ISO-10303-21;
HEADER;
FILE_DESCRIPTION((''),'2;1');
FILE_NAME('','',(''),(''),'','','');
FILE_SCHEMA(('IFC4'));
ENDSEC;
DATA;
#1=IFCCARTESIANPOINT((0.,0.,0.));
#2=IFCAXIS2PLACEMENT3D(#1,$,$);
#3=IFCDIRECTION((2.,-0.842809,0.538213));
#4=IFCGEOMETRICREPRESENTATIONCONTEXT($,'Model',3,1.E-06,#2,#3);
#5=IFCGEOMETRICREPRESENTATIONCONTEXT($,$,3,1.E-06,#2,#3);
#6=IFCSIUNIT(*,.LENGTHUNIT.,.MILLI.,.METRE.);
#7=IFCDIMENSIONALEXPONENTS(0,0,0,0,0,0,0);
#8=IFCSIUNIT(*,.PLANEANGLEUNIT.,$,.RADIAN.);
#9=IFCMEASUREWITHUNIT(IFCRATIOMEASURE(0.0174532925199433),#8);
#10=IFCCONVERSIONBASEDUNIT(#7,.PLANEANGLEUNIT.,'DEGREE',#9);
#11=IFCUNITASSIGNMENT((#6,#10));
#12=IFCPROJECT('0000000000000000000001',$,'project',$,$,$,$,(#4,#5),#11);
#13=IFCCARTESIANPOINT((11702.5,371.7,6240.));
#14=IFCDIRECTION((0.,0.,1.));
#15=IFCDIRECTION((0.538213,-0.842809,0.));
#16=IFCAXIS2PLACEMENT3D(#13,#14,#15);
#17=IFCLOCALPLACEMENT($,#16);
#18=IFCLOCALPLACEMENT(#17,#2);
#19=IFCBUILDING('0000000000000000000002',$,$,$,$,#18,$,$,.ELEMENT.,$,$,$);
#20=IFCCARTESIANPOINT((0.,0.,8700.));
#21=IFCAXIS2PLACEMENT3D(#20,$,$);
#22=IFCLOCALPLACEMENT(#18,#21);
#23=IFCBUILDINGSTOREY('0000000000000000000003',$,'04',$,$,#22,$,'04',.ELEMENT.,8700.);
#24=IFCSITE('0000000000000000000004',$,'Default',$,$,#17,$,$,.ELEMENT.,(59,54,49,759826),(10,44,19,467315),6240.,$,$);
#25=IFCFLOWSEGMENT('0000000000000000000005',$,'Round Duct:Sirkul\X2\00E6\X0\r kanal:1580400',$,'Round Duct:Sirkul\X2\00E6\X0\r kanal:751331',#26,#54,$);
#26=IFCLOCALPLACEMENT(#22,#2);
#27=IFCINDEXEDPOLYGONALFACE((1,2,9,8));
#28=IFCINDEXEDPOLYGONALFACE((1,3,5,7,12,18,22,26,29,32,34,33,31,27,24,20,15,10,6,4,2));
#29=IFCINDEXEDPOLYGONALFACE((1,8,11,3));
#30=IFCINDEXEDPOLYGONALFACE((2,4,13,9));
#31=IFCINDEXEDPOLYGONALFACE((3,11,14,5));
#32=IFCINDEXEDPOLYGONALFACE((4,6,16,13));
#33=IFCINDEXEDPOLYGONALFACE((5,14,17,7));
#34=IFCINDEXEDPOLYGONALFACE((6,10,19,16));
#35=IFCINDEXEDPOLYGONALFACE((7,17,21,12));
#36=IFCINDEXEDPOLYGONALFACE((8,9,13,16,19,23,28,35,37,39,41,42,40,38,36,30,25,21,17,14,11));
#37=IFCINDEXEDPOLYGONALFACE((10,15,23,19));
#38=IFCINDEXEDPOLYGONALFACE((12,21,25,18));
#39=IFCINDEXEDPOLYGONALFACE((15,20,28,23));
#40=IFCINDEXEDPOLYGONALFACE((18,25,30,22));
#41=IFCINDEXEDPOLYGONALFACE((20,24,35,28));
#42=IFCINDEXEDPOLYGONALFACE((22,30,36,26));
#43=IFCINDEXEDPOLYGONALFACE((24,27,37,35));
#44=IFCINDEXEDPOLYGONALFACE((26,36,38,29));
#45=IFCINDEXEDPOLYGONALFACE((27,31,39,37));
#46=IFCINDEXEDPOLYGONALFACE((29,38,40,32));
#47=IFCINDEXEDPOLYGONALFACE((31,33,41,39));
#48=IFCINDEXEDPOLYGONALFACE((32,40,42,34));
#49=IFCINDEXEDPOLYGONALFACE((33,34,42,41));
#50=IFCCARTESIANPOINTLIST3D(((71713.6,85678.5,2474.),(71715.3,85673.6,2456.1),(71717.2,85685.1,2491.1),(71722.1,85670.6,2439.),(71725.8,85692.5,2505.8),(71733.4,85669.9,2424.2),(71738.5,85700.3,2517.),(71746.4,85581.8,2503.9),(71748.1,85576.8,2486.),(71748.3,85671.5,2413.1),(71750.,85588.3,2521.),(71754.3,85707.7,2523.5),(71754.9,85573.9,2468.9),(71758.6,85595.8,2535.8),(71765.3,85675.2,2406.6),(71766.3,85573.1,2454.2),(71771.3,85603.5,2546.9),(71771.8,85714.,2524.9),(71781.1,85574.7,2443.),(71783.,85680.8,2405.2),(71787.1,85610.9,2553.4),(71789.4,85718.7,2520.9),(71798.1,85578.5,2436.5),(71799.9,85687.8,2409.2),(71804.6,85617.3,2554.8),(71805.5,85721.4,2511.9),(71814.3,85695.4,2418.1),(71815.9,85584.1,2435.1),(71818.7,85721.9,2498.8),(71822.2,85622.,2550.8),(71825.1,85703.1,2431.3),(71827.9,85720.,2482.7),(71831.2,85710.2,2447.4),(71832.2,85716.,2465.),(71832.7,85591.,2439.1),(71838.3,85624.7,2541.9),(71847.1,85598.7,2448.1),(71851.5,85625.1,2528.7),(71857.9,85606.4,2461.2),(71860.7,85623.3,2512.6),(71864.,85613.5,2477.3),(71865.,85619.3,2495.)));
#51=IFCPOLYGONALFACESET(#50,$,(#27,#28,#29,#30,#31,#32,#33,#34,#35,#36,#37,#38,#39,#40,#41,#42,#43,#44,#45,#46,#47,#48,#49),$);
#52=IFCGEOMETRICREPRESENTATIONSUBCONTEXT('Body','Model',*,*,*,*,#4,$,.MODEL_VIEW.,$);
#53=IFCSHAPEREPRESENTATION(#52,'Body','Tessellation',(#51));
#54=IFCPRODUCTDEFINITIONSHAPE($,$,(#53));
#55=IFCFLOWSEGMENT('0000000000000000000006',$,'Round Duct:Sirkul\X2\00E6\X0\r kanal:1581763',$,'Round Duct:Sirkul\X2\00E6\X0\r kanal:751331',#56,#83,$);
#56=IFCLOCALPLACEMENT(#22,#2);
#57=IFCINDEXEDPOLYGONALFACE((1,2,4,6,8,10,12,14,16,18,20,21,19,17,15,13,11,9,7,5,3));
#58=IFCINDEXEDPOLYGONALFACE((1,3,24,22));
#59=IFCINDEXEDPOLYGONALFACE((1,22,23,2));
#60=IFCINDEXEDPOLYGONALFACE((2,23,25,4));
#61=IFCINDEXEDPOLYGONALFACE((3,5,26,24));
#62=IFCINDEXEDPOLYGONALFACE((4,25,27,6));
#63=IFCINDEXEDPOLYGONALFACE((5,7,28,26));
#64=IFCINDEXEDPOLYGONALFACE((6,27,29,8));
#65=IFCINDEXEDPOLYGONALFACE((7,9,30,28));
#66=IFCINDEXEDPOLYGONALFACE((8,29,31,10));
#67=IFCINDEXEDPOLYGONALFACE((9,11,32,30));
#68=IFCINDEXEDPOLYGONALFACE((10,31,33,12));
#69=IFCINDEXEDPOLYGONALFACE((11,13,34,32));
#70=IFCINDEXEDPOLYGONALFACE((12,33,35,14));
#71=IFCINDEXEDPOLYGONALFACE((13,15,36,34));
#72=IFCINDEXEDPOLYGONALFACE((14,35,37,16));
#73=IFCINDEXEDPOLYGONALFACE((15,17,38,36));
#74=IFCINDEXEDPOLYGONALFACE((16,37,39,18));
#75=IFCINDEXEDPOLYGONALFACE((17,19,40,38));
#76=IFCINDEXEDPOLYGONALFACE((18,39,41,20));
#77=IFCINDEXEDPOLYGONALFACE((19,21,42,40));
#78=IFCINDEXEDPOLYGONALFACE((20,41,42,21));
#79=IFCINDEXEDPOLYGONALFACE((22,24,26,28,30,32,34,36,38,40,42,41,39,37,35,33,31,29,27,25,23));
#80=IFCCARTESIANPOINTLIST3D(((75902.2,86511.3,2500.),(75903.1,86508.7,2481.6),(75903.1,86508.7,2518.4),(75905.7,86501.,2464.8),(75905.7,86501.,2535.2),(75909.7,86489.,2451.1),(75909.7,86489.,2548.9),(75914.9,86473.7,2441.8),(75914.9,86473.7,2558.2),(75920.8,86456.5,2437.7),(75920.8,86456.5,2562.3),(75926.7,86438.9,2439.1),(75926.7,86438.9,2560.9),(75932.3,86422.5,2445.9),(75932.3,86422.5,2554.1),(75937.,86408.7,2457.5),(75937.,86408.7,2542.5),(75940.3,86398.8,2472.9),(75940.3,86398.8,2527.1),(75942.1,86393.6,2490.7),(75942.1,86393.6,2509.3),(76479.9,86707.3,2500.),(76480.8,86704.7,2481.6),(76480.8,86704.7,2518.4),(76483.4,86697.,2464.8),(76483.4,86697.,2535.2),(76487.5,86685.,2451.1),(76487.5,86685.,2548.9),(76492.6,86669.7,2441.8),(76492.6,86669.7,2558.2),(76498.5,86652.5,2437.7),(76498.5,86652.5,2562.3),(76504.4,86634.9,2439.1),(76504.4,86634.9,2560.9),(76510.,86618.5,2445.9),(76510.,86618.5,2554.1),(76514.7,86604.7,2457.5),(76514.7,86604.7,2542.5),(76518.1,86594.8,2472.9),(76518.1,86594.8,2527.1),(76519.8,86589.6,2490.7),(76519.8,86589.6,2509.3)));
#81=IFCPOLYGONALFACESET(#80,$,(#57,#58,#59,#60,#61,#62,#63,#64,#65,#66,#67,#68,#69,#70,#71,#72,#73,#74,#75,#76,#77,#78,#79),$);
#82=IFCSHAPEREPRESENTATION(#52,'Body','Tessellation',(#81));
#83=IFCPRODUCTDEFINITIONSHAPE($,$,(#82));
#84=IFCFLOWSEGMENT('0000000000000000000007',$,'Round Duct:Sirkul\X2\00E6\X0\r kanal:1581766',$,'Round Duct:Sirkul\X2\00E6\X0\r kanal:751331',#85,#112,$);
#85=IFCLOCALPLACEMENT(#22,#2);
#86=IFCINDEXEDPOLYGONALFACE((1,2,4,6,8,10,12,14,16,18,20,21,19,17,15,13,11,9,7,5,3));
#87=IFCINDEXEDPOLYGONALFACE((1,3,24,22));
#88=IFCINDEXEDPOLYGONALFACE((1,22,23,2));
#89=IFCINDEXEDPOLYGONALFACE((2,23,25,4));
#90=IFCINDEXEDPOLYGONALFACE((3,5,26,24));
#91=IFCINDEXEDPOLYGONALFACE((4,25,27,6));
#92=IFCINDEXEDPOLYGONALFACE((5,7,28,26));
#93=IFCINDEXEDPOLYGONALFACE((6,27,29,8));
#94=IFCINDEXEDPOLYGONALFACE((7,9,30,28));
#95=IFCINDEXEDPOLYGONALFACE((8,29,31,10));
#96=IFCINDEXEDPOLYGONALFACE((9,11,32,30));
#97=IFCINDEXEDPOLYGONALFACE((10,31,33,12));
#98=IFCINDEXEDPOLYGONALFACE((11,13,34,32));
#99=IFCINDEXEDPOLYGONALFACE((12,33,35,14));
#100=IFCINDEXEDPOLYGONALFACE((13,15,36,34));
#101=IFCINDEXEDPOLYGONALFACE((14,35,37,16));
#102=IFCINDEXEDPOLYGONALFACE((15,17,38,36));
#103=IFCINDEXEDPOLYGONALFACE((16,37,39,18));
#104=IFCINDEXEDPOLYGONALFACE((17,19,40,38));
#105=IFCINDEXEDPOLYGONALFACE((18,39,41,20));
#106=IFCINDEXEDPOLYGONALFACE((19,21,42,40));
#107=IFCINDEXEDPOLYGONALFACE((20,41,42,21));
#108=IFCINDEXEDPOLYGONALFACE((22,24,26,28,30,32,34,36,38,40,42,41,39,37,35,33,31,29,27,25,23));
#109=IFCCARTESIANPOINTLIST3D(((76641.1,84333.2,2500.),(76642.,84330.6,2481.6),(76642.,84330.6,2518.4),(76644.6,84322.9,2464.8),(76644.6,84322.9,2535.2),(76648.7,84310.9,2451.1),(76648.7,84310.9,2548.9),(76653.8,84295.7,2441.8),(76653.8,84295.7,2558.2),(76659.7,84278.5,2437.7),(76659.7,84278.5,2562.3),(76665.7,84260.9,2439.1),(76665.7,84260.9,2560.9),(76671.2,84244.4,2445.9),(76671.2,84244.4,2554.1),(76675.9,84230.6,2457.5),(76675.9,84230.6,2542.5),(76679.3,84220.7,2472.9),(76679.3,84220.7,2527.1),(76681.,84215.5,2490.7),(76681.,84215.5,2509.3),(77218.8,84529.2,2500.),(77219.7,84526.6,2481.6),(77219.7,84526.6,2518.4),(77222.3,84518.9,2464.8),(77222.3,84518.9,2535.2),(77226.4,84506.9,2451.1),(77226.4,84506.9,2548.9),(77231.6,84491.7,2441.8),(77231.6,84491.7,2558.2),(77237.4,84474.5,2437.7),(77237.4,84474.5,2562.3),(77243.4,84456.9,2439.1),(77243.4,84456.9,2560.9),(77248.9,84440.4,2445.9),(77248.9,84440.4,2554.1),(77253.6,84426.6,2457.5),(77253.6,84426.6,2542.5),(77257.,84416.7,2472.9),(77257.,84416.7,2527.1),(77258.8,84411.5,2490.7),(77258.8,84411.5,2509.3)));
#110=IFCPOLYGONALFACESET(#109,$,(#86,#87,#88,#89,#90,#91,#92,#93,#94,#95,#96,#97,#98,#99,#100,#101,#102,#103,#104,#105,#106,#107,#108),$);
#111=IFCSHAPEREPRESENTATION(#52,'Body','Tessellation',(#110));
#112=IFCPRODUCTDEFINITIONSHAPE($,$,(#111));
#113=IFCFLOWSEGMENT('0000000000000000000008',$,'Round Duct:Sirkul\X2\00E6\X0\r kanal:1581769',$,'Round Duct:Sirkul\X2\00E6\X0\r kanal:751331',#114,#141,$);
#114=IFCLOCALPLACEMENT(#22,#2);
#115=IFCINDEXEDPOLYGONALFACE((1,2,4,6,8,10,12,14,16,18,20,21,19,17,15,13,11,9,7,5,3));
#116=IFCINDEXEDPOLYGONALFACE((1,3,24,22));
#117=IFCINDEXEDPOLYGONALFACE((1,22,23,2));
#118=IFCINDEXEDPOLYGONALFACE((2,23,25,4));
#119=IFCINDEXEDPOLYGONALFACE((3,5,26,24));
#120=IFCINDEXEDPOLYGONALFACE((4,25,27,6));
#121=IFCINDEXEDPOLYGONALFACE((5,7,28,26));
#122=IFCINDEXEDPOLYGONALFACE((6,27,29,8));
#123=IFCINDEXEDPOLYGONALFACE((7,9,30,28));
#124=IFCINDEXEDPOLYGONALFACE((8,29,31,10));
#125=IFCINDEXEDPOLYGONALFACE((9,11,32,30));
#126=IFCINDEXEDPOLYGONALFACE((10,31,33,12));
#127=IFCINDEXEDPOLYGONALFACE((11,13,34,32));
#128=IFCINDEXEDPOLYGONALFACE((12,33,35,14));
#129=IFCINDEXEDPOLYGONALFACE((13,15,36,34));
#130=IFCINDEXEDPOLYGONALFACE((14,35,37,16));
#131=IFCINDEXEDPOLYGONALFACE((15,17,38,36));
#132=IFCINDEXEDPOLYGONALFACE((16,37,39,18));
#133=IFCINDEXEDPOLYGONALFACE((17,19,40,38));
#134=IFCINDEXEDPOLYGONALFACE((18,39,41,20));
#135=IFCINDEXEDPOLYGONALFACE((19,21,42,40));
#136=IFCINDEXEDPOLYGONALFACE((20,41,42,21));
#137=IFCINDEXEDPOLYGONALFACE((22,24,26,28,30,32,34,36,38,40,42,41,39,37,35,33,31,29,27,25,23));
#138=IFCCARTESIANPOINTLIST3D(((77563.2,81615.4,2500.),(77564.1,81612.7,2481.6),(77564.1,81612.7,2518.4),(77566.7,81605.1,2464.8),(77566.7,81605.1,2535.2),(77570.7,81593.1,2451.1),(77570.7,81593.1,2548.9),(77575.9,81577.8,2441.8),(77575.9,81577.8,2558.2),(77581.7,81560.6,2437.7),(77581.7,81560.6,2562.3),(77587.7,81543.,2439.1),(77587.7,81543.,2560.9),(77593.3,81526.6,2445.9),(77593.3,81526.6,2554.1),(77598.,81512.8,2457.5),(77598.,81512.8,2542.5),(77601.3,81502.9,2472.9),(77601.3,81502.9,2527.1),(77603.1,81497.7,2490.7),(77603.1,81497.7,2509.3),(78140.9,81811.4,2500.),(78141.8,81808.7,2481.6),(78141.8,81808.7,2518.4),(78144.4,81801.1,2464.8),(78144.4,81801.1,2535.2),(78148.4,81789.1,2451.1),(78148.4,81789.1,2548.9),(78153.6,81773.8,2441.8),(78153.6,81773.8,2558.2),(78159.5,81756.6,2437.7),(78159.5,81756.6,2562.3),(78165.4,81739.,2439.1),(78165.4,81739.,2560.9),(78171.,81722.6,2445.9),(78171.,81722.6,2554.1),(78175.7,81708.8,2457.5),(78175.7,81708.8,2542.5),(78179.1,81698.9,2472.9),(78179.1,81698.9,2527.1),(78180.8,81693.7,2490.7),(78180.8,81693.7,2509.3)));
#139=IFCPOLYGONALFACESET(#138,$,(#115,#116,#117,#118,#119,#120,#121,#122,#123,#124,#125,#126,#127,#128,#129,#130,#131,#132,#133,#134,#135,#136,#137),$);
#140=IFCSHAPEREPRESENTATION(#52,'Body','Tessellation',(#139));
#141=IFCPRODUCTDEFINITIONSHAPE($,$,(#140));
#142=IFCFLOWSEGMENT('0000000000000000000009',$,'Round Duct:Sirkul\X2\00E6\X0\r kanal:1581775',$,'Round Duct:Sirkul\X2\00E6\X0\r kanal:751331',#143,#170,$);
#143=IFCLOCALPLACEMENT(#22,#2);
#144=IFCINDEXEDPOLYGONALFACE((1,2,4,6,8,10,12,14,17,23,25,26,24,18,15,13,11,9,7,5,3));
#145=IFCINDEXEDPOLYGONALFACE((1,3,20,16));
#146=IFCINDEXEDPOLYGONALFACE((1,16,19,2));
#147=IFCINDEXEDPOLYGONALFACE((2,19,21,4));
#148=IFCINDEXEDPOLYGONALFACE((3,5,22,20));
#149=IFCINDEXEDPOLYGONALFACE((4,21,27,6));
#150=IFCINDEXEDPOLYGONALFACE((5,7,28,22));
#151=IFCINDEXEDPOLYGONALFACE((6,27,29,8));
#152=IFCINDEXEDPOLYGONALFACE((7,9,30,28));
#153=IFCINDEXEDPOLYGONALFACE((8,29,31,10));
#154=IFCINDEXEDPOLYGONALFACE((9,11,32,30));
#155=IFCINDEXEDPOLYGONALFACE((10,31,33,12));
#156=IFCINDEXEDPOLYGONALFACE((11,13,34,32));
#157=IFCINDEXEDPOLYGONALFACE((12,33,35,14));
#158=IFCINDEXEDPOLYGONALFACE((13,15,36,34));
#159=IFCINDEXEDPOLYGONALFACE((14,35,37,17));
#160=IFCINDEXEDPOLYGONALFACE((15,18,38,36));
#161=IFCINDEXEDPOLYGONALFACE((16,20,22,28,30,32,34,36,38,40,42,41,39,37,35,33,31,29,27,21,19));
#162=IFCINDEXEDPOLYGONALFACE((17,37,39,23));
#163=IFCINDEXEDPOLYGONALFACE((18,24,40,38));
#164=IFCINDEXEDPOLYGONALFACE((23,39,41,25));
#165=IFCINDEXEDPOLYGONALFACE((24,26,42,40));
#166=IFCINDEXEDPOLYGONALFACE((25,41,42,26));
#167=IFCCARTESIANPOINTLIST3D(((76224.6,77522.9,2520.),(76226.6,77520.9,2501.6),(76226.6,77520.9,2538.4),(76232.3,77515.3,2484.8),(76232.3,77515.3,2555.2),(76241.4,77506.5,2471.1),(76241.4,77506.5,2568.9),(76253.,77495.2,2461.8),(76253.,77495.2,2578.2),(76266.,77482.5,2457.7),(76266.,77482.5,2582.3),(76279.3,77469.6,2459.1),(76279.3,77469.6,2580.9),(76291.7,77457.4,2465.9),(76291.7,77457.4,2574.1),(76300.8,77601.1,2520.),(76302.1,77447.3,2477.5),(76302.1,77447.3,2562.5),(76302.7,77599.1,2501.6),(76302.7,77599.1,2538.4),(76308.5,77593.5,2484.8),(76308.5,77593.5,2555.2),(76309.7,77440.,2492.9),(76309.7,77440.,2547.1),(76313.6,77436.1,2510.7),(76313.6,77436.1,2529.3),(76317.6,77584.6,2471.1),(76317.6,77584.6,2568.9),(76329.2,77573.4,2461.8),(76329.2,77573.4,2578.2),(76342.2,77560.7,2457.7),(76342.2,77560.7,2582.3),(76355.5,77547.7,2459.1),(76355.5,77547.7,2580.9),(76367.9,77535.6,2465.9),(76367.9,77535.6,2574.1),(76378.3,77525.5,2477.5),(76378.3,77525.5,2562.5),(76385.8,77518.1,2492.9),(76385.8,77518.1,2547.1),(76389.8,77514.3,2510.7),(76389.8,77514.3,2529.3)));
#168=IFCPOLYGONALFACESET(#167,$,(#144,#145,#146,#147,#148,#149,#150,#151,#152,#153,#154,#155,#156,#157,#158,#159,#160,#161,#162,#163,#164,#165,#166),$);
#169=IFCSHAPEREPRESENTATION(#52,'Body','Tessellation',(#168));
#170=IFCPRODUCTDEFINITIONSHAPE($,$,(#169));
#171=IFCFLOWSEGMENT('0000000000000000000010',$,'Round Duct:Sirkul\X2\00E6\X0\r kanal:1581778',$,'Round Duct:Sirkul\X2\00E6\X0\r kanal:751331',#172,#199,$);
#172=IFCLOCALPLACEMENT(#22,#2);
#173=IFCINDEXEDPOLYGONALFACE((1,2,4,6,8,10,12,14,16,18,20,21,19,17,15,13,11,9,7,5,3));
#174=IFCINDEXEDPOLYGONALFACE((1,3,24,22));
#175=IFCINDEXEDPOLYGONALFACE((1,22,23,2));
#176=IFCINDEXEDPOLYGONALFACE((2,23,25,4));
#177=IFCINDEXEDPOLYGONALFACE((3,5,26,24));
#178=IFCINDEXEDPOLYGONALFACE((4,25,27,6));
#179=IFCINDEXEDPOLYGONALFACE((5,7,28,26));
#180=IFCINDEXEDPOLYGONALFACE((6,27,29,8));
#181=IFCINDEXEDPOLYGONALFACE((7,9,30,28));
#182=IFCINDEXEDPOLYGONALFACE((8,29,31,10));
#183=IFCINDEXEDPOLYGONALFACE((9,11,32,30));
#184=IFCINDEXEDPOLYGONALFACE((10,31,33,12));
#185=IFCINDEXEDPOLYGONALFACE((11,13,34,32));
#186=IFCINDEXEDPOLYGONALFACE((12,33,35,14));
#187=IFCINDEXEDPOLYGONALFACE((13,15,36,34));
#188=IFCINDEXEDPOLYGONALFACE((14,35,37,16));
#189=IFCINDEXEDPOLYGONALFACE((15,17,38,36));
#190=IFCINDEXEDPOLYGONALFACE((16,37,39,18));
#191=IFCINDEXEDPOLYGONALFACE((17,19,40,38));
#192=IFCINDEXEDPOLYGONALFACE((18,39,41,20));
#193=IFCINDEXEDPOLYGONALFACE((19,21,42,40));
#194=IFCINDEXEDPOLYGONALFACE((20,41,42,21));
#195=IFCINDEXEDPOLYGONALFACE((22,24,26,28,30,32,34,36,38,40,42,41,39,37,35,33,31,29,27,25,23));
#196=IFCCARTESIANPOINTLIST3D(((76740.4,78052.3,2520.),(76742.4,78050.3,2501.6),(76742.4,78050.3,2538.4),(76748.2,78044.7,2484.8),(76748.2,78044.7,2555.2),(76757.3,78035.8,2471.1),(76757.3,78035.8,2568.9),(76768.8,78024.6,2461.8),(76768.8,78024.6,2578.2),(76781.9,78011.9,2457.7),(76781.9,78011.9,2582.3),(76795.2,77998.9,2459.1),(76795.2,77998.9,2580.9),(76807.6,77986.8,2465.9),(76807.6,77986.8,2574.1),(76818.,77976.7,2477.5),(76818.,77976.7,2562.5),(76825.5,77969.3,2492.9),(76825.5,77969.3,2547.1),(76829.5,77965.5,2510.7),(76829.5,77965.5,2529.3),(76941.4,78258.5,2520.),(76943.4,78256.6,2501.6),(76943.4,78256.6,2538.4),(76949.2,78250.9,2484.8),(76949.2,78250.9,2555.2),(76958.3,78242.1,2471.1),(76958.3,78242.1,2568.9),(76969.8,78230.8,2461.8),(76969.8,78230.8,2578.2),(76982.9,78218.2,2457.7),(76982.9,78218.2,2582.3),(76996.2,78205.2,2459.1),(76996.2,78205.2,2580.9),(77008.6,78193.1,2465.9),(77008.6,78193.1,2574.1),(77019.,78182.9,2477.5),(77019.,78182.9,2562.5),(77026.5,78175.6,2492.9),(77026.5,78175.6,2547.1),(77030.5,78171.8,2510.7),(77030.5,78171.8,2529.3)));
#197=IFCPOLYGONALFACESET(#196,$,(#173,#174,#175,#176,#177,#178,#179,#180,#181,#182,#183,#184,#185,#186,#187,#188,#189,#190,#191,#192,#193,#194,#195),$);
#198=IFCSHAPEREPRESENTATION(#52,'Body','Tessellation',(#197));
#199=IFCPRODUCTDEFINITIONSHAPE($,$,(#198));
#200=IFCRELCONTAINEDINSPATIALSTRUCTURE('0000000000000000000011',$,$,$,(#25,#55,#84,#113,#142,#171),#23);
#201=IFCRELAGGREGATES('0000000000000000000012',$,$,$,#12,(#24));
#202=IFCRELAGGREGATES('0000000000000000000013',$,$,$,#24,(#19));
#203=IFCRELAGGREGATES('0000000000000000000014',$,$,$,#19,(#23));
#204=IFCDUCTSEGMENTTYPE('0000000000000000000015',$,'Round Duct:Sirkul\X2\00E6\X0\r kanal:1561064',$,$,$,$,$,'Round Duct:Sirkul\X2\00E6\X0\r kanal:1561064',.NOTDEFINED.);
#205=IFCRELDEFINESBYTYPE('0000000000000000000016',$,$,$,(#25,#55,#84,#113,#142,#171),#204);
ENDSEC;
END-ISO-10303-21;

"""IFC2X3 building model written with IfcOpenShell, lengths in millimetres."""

from ifc_helpers import new_model, entity, si_unit, converted_unit, direction, frame, frame_2d, origin, origin_2d_with_axis, place, context, subcontext, project, spatial, circle, extrude, type_object, element, save


model = new_model("IFC2X3")

# Units and contexts
model_context = context("Model", 3, precision=1e-06, world=origin(), true_north=direction((2.0, -0.842809, 0.538213)))
context_of_model = context(None, 3, precision=1e-06, world=origin(), true_north=direction((2.0, -0.842809, 0.538213)))
body_context = subcontext(model_context, "Body", "Model", "MODEL_VIEW")
ifc_project = project(units=[si_unit("LENGTHUNIT", "METRE", prefix="MILLI"), converted_unit("PLANEANGLEUNIT", "DEGREE", entity("IfcRatioMeasure", 0.0174532925199433), si_unit("PLANEANGLEUNIT", "RADIAN"), dimensions=[0, 0, 0, 0, 0, 0, 0])], contexts=[model_context, context_of_model])

# Site, building, storey
site_placement = place(None, frame((11702.5, 371.7, 6240.0), z_axis=(0.0, 0.0, 1.0), x_axis=(0.538213, -0.842809, 0.0)))
site = spatial("IfcSite", under=ifc_project, at=site_placement, Name="Default", CompositionType="ELEMENT", RefLatitude=(59, 54, 49, 759826), RefLongitude=(10, 44, 19, 467315), RefElevation=6240.0)
building_placement = place(site_placement, origin())
building = spatial("IfcBuilding", under=site, at=building_placement, CompositionType="ELEMENT")
storey_placement = place(building_placement, frame((0.0, 0.0, 8700.0)))
storey = spatial("IfcBuildingStorey", under=building, at=storey_placement, Name="04", LongName="04", CompositionType="ELEMENT", Elevation=8700.0)

# Flow segments
duct_segment_type = type_object("IfcDuctSegmentType", Name="Round Duct:Sirkulær kanal:1561064", ElementType="Round Duct:Sirkulær kanal:1561064", PredefinedType="NOTDEFINED")
flow_segment_1_placement = place(storey_placement, origin())
element("IfcFlowSegment", 1, at=flow_segment_1_placement, inside=storey, type_object=duct_segment_type, Name="Round Duct:Sirkulær kanal:1580400", ObjectType="Round Duct:Sirkulær kanal:751331", context=body_context, shape_type="SweptSolid", body=[
    extrude(circle(Radius=62.5, at=frame_2d((0.0, 0.0), x_axis=(1.0, 0.0))), frame((71805.8, 85599.2, 2495.0), z_axis=(-0.308323, 0.908811, -0.281068), x_axis=(0.946986, 0.321274, 0.0)), (0.0, 0.0, 1.0), 106.5),
])
flow_segment_2_placement = place(storey_placement, origin())
element("IfcFlowSegment", 2, at=flow_segment_2_placement, inside=storey, type_object=duct_segment_type, Name="Round Duct:Sirkulær kanal:1581763", ObjectType="Round Duct:Sirkulær kanal:751331", context=body_context, shape_type="SweptSolid", body=[
    extrude(circle(Radius=62.5, at=frame_2d((0.0, 0.0), x_axis=(1.0, 0.0))), frame((75922.3, 86452.1, 2500.0), z_axis=(0.946986, 0.321274, 0.0), x_axis=(-0.321274, 0.946986, 0.0)), (0.0, 0.0, 1.0), 610.1),
])
flow_segment_3_placement = place(storey_placement, origin())
element("IfcFlowSegment", 3, at=flow_segment_3_placement, inside=storey, type_object=duct_segment_type, Name="Round Duct:Sirkulær kanal:1581766", ObjectType="Round Duct:Sirkulær kanal:751331", context=body_context, shape_type="SweptSolid", body=[
    extrude(circle(Radius=62.5, at=frame_2d((0.0, 0.0), x_axis=(1.0, 0.0))), frame((76661.2, 84274.0, 2500.0), z_axis=(0.946986, 0.321274, 0.0), x_axis=(-0.321274, 0.946986, 0.0)), (0.0, 0.0, 1.0), 610.1),
])
flow_segment_4_placement = place(storey_placement, origin())
element("IfcFlowSegment", 4, at=flow_segment_4_placement, inside=storey, type_object=duct_segment_type, Name="Round Duct:Sirkulær kanal:1581769", ObjectType="Round Duct:Sirkulær kanal:751331", context=body_context, shape_type="SweptSolid", body=[
    extrude(circle(Radius=62.5, at=frame_2d((0.0, 0.0), x_axis=(1.0, 0.0))), frame((77583.2, 81556.2, 2500.0), z_axis=(0.946986, 0.321274, 0.0), x_axis=(-0.321274, 0.946986, 0.0)), (0.0, 0.0, 1.0), 610.1),
])
flow_segment_5_placement = place(storey_placement, origin())
element("IfcFlowSegment", 5, at=flow_segment_5_placement, inside=storey, type_object=duct_segment_type, Name="Round Duct:Sirkulær kanal:1581775", ObjectType="Round Duct:Sirkulær kanal:751331", context=body_context, shape_type="SweptSolid", body=[
    extrude(circle(Radius=62.5, at=origin_2d_with_axis()), frame((76269.3, 77479.3, 2520.0), z_axis=(0.697915, 0.71618, 0.0), x_axis=(-0.71618, 0.697915, 0.0)), (0.0, 0.0, 1.0), 109.2),
])
flow_segment_6_placement = place(storey_placement, origin())
element("IfcFlowSegment", 6, at=flow_segment_6_placement, inside=storey, type_object=duct_segment_type, Name="Round Duct:Sirkulær kanal:1581778", ObjectType="Round Duct:Sirkulær kanal:751331", context=body_context, shape_type="SweptSolid", body=[
    extrude(circle(Radius=62.5, at=origin_2d_with_axis()), frame((76785.2, 78008.6, 2520.0), z_axis=(0.697915, 0.71618, 0.0), x_axis=(-0.71618, 0.697915, 0.0)), (0.0, 0.0, 1.0), 288.0),
])

save(model, "model.ifc")
